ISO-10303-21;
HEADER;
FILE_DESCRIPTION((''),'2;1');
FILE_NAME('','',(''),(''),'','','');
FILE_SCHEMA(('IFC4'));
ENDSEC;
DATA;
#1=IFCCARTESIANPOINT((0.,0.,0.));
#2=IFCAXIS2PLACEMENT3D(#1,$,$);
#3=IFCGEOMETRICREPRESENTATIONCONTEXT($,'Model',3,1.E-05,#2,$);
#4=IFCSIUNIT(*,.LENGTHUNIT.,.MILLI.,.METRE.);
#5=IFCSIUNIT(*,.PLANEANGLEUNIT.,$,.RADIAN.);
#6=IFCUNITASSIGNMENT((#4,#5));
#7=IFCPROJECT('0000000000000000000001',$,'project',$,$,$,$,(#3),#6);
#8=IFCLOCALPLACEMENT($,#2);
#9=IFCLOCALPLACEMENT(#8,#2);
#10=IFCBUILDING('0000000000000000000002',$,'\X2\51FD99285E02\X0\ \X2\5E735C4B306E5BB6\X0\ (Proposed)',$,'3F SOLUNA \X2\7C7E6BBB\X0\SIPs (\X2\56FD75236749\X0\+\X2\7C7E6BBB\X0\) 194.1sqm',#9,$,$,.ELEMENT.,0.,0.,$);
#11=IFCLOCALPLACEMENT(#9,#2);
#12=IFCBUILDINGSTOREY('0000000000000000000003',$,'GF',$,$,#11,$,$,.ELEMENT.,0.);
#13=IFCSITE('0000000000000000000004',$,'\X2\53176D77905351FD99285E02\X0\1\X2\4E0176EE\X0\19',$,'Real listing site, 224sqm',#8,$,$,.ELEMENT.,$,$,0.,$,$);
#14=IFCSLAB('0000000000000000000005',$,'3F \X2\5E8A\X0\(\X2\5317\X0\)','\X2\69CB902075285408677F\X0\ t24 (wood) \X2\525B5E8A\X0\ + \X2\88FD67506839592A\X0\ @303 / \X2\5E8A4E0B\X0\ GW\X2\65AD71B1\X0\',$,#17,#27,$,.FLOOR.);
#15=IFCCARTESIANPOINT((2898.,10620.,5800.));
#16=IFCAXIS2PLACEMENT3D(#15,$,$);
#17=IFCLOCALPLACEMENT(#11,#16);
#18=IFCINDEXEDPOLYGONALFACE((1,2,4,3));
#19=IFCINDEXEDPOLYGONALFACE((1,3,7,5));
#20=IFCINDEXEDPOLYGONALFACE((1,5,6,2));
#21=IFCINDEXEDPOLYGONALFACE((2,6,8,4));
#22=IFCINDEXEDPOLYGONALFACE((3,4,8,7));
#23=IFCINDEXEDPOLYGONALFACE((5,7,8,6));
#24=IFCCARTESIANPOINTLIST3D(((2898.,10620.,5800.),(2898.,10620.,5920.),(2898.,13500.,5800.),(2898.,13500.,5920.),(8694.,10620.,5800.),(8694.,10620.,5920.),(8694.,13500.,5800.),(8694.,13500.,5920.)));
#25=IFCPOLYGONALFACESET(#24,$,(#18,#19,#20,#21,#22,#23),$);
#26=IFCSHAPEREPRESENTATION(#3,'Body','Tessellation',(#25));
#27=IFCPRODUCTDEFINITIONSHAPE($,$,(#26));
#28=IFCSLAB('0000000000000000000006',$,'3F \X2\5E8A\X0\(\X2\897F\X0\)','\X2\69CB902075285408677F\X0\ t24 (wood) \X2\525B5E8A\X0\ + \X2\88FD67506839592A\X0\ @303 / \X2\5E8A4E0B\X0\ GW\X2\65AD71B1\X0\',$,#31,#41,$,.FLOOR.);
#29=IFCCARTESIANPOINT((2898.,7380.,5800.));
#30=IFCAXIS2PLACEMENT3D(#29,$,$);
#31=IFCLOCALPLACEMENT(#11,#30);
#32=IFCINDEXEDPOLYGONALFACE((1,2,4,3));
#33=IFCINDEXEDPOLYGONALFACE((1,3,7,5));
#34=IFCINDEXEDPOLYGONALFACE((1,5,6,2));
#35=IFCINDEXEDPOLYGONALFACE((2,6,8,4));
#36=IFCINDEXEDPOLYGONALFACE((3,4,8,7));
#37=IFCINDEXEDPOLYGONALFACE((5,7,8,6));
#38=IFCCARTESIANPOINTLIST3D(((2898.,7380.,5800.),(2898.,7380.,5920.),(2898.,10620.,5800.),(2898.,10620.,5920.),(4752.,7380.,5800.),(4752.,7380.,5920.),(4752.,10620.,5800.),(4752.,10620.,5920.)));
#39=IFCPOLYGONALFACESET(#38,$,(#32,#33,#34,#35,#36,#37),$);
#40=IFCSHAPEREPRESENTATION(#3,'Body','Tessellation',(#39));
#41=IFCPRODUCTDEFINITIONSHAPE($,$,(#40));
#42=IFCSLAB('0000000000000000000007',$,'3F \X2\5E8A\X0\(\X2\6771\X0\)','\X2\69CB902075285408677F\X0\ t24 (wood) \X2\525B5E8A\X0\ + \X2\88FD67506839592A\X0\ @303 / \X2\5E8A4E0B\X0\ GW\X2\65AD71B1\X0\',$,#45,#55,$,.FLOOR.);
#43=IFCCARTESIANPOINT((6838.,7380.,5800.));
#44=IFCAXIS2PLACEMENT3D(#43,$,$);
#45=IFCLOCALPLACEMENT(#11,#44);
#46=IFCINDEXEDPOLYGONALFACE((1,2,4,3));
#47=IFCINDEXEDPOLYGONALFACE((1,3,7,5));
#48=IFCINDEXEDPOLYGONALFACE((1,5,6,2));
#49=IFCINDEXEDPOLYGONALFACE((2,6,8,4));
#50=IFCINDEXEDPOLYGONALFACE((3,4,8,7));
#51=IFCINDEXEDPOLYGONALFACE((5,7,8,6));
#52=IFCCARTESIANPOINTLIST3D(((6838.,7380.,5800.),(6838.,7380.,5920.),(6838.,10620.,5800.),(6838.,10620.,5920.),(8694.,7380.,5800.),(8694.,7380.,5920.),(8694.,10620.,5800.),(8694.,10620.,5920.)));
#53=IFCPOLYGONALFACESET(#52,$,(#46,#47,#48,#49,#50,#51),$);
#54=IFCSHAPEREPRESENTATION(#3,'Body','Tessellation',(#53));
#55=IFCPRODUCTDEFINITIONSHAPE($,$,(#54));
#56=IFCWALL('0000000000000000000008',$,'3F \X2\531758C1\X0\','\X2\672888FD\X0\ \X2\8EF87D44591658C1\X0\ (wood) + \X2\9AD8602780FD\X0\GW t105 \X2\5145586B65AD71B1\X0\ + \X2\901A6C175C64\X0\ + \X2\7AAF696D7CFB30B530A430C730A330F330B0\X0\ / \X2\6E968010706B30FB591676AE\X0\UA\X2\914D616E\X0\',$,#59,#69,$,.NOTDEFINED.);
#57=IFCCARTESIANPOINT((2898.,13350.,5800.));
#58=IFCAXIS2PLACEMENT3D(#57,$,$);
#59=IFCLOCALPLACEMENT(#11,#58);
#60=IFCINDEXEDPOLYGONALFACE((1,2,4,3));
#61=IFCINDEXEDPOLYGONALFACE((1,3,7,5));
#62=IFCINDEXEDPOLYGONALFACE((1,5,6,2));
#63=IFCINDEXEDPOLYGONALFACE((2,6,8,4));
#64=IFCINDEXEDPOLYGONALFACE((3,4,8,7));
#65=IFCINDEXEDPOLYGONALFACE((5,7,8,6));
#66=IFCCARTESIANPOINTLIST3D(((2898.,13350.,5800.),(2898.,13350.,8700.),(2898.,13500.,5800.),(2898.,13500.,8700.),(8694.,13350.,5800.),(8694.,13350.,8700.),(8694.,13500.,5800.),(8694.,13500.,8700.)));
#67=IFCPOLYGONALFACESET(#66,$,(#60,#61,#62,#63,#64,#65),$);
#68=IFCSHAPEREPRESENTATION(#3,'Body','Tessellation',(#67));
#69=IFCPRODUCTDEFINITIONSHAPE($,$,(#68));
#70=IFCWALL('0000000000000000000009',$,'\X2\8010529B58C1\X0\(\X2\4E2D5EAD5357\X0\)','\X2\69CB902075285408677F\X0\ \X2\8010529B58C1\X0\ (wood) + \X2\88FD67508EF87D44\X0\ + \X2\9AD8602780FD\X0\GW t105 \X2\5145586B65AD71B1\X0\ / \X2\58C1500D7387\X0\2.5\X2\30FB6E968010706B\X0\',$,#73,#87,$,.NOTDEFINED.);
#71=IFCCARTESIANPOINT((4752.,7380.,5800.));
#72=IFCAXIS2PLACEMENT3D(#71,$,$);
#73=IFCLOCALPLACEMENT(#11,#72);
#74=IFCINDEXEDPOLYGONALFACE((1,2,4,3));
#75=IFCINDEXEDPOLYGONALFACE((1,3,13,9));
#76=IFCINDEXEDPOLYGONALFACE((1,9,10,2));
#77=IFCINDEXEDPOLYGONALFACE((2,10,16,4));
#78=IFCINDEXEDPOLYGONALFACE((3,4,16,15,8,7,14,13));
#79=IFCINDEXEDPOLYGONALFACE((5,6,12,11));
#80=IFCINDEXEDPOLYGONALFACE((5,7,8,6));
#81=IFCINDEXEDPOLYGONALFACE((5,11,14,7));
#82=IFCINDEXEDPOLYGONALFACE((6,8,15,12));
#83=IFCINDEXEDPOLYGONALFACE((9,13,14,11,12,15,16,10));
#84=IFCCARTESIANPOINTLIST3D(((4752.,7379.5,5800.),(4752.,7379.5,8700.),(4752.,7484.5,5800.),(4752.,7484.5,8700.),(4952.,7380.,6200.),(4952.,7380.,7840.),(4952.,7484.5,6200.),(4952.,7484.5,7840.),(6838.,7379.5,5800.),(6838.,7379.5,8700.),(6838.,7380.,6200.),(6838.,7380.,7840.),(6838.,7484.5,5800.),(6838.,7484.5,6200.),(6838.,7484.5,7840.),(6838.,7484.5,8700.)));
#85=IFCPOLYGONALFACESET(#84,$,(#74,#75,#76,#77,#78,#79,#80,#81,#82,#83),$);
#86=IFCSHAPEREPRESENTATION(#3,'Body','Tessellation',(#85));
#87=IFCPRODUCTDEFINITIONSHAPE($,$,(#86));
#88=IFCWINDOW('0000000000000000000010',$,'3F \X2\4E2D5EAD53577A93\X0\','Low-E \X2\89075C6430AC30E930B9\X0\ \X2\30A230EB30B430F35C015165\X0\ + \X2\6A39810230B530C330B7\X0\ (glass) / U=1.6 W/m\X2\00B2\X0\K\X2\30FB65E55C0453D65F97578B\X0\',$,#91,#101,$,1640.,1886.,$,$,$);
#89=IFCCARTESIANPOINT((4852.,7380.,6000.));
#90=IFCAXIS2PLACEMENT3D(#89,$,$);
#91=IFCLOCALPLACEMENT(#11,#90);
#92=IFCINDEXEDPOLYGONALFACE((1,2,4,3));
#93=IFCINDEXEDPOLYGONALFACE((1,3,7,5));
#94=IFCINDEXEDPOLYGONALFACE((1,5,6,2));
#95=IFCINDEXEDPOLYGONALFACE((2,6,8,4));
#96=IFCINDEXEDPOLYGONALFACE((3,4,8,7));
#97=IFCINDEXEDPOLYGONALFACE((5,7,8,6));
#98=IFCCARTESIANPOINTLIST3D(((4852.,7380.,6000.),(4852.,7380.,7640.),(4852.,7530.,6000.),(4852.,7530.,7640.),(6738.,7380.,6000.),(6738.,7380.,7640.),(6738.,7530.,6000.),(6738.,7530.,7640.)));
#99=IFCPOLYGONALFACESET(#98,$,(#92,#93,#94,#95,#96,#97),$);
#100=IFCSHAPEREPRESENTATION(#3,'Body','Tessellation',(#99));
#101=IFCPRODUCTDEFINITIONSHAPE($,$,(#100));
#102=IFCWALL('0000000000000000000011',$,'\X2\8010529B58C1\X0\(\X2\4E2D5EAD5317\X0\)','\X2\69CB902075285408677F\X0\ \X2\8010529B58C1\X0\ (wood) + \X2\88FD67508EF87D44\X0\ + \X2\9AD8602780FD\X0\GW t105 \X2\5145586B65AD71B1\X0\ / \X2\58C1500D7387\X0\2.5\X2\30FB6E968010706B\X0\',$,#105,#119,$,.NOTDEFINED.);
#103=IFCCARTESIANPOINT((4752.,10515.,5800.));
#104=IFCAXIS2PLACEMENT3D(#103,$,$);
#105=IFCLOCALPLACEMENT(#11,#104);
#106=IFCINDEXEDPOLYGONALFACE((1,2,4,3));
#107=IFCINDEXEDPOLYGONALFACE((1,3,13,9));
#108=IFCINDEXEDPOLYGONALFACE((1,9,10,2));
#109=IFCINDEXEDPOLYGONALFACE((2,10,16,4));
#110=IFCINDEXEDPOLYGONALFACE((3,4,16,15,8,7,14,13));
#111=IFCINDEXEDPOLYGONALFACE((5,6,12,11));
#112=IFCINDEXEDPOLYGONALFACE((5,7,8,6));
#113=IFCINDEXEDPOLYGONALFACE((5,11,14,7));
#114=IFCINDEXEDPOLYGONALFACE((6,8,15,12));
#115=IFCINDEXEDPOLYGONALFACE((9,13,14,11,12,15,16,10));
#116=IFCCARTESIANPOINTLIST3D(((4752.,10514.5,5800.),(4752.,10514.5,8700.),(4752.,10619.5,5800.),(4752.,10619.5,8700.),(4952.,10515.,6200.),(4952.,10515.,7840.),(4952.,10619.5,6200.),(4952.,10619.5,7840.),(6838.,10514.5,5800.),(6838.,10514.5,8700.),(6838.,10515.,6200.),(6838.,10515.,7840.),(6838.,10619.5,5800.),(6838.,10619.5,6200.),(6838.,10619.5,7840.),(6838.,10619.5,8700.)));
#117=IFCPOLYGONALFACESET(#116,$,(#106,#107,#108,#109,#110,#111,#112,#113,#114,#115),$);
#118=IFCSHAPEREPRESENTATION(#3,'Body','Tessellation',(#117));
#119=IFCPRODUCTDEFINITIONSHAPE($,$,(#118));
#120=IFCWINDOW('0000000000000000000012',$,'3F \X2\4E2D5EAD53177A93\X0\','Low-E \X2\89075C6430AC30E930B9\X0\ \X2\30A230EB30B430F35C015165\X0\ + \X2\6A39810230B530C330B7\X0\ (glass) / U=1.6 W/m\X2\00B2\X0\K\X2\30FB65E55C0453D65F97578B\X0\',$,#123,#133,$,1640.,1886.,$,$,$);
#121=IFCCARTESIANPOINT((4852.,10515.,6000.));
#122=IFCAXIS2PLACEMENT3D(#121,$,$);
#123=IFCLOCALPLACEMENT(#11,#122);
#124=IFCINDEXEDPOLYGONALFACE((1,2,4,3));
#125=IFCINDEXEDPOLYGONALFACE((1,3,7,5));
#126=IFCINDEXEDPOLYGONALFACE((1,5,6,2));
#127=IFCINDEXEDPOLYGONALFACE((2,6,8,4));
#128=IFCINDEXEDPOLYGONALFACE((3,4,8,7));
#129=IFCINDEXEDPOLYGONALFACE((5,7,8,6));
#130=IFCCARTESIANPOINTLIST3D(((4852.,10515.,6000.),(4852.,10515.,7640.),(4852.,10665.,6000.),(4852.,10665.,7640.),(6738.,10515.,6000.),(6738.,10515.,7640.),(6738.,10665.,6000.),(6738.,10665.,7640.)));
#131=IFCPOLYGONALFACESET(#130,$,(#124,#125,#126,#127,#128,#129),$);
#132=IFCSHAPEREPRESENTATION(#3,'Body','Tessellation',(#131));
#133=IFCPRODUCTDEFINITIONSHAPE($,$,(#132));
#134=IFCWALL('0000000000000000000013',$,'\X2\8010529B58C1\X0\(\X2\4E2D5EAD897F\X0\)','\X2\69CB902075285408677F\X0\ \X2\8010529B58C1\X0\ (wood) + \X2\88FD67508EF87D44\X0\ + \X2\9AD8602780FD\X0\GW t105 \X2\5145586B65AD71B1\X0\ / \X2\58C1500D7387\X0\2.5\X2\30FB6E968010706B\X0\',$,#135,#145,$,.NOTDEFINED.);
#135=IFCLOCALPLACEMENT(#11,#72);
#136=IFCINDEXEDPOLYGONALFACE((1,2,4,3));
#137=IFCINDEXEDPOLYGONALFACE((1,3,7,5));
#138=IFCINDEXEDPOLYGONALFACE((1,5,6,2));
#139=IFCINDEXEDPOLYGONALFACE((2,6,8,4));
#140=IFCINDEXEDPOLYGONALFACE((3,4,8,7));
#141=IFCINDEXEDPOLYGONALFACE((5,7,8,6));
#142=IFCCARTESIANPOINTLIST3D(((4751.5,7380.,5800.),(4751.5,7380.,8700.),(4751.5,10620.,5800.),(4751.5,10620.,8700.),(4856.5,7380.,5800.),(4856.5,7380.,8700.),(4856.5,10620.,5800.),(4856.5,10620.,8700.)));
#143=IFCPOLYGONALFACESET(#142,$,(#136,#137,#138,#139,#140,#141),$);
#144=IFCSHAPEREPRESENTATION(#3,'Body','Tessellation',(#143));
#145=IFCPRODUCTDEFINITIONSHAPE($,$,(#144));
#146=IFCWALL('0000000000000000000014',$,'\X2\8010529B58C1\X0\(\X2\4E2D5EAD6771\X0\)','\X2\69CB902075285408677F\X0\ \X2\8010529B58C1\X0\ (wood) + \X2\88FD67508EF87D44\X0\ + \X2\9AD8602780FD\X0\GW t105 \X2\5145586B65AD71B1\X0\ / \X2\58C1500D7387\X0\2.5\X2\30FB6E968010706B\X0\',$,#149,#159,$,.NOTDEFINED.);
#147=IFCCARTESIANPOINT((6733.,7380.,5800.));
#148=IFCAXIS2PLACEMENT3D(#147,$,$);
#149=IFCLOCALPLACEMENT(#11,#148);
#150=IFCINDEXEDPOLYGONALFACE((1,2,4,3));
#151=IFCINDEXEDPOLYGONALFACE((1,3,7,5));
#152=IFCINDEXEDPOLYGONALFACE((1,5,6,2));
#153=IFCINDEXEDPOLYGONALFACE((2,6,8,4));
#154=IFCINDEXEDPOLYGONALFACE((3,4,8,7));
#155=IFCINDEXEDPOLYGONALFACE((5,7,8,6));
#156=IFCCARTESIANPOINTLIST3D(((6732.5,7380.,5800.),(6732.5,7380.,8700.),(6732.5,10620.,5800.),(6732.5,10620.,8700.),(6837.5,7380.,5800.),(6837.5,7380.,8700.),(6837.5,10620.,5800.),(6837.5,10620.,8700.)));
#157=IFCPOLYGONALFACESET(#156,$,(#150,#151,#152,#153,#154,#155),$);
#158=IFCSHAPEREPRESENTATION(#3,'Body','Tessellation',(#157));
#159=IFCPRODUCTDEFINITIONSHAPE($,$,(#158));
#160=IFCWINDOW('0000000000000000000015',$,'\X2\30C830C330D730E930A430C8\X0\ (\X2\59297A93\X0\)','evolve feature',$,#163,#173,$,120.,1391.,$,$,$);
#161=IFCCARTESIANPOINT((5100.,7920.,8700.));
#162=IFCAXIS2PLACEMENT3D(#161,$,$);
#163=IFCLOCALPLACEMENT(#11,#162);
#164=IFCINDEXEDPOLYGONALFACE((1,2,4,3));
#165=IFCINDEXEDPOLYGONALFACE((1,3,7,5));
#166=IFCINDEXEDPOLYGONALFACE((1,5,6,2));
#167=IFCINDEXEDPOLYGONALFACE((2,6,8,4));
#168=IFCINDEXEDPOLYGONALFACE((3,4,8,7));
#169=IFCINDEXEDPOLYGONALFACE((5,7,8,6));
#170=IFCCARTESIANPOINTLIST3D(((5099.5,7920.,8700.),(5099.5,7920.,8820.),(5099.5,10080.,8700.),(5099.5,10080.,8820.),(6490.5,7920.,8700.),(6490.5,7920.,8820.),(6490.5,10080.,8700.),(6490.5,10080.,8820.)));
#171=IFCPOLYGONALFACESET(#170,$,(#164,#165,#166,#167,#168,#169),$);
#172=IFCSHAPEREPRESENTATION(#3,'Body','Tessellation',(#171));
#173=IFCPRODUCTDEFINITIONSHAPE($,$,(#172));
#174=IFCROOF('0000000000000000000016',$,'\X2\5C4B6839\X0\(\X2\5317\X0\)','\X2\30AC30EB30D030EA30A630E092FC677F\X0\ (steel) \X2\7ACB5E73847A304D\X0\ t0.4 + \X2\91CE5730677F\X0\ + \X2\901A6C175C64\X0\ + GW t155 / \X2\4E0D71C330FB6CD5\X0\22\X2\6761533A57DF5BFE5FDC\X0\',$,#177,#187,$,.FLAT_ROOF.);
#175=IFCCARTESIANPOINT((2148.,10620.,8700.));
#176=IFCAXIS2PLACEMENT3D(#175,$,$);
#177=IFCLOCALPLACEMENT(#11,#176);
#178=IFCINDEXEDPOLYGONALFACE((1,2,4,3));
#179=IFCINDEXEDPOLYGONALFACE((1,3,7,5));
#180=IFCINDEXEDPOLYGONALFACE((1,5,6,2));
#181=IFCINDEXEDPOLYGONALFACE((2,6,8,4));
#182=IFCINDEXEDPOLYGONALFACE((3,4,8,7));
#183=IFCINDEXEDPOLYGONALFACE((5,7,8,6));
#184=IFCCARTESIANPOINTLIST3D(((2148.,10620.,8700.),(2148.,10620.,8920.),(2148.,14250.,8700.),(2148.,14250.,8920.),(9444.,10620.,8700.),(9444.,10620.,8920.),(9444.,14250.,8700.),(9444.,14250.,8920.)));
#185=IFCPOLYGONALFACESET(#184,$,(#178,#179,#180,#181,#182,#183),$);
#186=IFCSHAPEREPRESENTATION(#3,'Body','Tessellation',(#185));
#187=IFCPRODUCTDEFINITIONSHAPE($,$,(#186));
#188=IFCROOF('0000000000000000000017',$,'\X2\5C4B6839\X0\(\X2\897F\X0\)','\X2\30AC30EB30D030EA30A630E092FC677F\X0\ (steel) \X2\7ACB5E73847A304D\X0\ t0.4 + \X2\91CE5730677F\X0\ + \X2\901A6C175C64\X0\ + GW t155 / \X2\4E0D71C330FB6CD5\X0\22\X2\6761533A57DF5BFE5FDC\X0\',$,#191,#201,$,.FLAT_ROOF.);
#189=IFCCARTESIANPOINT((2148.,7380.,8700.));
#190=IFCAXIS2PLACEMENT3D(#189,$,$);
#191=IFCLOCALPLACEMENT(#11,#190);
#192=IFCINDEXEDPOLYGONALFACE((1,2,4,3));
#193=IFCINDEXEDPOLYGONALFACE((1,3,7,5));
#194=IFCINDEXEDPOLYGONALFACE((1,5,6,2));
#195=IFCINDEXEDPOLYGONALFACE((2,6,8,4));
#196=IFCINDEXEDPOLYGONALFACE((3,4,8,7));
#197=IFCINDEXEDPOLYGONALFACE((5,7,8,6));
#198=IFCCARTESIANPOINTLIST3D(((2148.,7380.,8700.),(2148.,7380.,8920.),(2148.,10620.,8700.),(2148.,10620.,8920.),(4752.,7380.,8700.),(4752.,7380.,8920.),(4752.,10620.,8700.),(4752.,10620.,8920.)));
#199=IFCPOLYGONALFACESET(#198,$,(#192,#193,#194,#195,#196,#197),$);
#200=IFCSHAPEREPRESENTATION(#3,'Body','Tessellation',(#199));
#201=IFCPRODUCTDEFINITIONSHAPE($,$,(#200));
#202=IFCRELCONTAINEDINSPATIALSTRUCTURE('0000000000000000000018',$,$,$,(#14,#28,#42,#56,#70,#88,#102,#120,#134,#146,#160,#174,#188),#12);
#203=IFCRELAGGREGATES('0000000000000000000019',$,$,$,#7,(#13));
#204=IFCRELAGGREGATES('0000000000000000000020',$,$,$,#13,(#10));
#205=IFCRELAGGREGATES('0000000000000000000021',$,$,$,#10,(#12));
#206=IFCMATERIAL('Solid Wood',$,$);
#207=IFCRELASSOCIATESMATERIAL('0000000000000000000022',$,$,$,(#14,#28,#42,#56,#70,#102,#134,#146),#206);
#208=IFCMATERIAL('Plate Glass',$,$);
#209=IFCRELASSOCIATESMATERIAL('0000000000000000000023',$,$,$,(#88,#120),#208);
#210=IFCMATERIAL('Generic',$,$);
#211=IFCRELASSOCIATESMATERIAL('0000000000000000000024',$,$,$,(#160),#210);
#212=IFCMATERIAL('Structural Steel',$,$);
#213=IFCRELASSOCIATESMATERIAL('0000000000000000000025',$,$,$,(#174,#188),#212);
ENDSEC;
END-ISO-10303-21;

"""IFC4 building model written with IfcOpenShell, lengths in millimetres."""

from ifc_helpers import new_model, si_unit, frame, frame_2d, origin, place, context, project, spatial, rectangle, extrude, material, element, fill, save


model = new_model("IFC4")

# Units and contexts
model_context = context("Model", 3, precision=1e-05, world=origin())
ifc_project = project(units=[si_unit("LENGTHUNIT", "METRE", prefix="MILLI"), si_unit("PLANEANGLEUNIT", "RADIAN")], contexts=[model_context])

# Site, building, storey
site_placement = place(None, origin())
site = spatial("IfcSite", under=ifc_project, at=site_placement, Name="北海道函館市1丁目19", ObjectType="Real listing site, 224sqm", CompositionType="ELEMENT", RefElevation=0.0)
building_placement = place(site_placement, origin())
building = spatial("IfcBuilding", under=site, at=building_placement, Name="函館市 平屋の家 (Proposed)", ObjectType="3F SOLUNA 籾殻SIPs (国産杉+籾殻) 194.1sqm", CompositionType="ELEMENT", ElevationOfRefHeight=0.0, ElevationOfTerrain=0.0)
storey_placement = place(building_placement, origin())
storey = spatial("IfcBuildingStorey", under=building, at=storey_placement, Name="GF", CompositionType="ELEMENT", Elevation=0.0)

# Slabs
ifc_material_1 = material(Name="Solid Wood")
slab_1_placement = place(storey_placement, frame((2898.0, 10620.0, 5800.0)))
element("IfcSlab", 1, at=slab_1_placement, inside=storey, material=ifc_material_1, Name="3F 床(北)", Description="構造用合板 t24 (wood) 剛床 + 製材根太 @303 / 床下 GW断熱", PredefinedType="FLOOR", context=model_context, shape_type="SweptSolid", body=[
    extrude(rectangle(XDim=5796.0, YDim=2880.0, at=frame_2d((2898.0, 1440.0))), frame((2898.0, 10620.0, 5800.0)), (0.0, 0.0, 1.0), 120.0),
])
slab_2_placement = place(storey_placement, frame((2898.0, 7380.0, 5800.0)))
element("IfcSlab", 2, at=slab_2_placement, inside=storey, material=ifc_material_1, Name="3F 床(西)", Description="構造用合板 t24 (wood) 剛床 + 製材根太 @303 / 床下 GW断熱", PredefinedType="FLOOR", context=model_context, shape_type="SweptSolid", body=[
    extrude(rectangle(XDim=1854.0, YDim=3240.0, at=frame_2d((927.0, 1620.0))), frame((2898.0, 7380.0, 5800.0)), (0.0, 0.0, 1.0), 120.0),
])
slab_3_placement = place(storey_placement, frame((6838.0, 7380.0, 5800.0)))
element("IfcSlab", 3, at=slab_3_placement, inside=storey, material=ifc_material_1, Name="3F 床(東)", Description="構造用合板 t24 (wood) 剛床 + 製材根太 @303 / 床下 GW断熱", PredefinedType="FLOOR", context=model_context, shape_type="SweptSolid", body=[
    extrude(rectangle(XDim=1856.0, YDim=3240.0, at=frame_2d((928.0, 1620.0))), frame((6838.0, 7380.0, 5800.0)), (0.0, 0.0, 1.0), 120.0),
])

# Wall
wall_1_placement = place(storey_placement, frame((2898.0, 13350.0, 5800.0)))
element("IfcWall", 4, at=wall_1_placement, inside=storey, material=ifc_material_1, Name="3F 北壁", Description="木製 軸組外壁 (wood) + 高性能GW t105 充填断熱 + 通気層 + 窯業系サイディング / 準耐火・外皮UA配慮", PredefinedType="NOTDEFINED", context=model_context, shape_type="SweptSolid", body=[
    extrude(rectangle(XDim=5796.0, YDim=150.0, at=frame_2d((2898.0, 75.0))), frame((2898.0, 13350.0, 5800.0)), (0.0, 0.0, 1.0), 2900.0),
])

# Walls, openings, windows
wall_2_placement = place(storey_placement, frame((4752.0, 7380.0, 5800.0)))
wall_2 = element("IfcWall", 5, at=wall_2_placement, inside=storey, material=ifc_material_1, Name="耐力壁(中庭南)", Description="構造用合板 耐力壁 (wood) + 製材軸組 + 高性能GW t105 充填断熱 / 壁倍率2.5・準耐火", PredefinedType="NOTDEFINED", context=model_context, shape_type="SweptSolid", body=[
    extrude(rectangle(XDim=2086.0, YDim=105.0, at=frame_2d((1043.0, 52.0))), frame((4752.0, 7380.0, 5800.0)), (0.0, 0.0, 1.0), 2900.0),
])
opening_1_placement = place(storey_placement, frame((4852.0, 7380.0, 6000.0)))
opening_1 = element("IfcOpeningElement", 6, at=opening_1_placement, cuts=wall_2, PredefinedType="NOTDEFINED", context=model_context, shape_type="SweptSolid", body=[
    extrude(rectangle(XDim=1886.0, YDim=150.0, at=frame_2d((943.0, 75.0))), frame((4852.0, 7380.0, 6000.0)), (0.0, 0.0, 1.0), 1640.0),
])
ifc_material_2 = material(Name="Plate Glass")
window_1_placement = place(storey_placement, frame((4852.0, 7380.0, 6000.0)))
window_1 = element("IfcWindow", 7, at=window_1_placement, inside=storey, material=ifc_material_2, Name="3F 中庭南窓", Description="Low-E 複層ガラス アルゴン封入 + 樹脂サッシ (glass) / U=1.6 W/m²K・日射取得型", OverallHeight=1640.0, OverallWidth=1886.0, context=model_context, shape_type="SweptSolid", body=[
    extrude(rectangle(XDim=1886.0, YDim=150.0, at=frame_2d((943.0, 75.0))), frame((4852.0, 7380.0, 6000.0)), (0.0, 0.0, 1.0), 1640.0),
])
fill(opening_1, window_1)
wall_3_placement = place(storey_placement, frame((4752.0, 10515.0, 5800.0)))
wall_3 = element("IfcWall", 8, at=wall_3_placement, inside=storey, material=ifc_material_1, Name="耐力壁(中庭北)", Description="構造用合板 耐力壁 (wood) + 製材軸組 + 高性能GW t105 充填断熱 / 壁倍率2.5・準耐火", PredefinedType="NOTDEFINED", context=model_context, shape_type="SweptSolid", body=[
    extrude(rectangle(XDim=2086.0, YDim=105.0, at=frame_2d((1043.0, 52.0))), frame((4752.0, 10515.0, 5800.0)), (0.0, 0.0, 1.0), 2900.0),
])
opening_2_placement = place(storey_placement, frame((4852.0, 10515.0, 6000.0)))
opening_2 = element("IfcOpeningElement", 9, at=opening_2_placement, cuts=wall_3, PredefinedType="NOTDEFINED", context=model_context, shape_type="SweptSolid", body=[
    extrude(rectangle(XDim=1886.0, YDim=150.0, at=frame_2d((943.0, 75.0))), frame((4852.0, 10515.0, 6000.0)), (0.0, 0.0, 1.0), 1640.0),
])
window_2_placement = place(storey_placement, frame((4852.0, 10515.0, 6000.0)))
window_2 = element("IfcWindow", 10, at=window_2_placement, inside=storey, material=ifc_material_2, Name="3F 中庭北窓", Description="Low-E 複層ガラス アルゴン封入 + 樹脂サッシ (glass) / U=1.6 W/m²K・日射取得型", OverallHeight=1640.0, OverallWidth=1886.0, context=model_context, shape_type="SweptSolid", body=[
    extrude(rectangle(XDim=1886.0, YDim=150.0, at=frame_2d((943.0, 75.0))), frame((4852.0, 10515.0, 6000.0)), (0.0, 0.0, 1.0), 1640.0),
])
fill(opening_2, window_2)

# Walls
wall_4_placement = place(storey_placement, frame((4752.0, 7380.0, 5800.0)))
element("IfcWall", 11, at=wall_4_placement, inside=storey, material=ifc_material_1, Name="耐力壁(中庭西)", Description="構造用合板 耐力壁 (wood) + 製材軸組 + 高性能GW t105 充填断熱 / 壁倍率2.5・準耐火", PredefinedType="NOTDEFINED", context=model_context, shape_type="SweptSolid", body=[
    extrude(rectangle(XDim=105.0, YDim=3240.0, at=frame_2d((52.0, 1620.0))), frame((4752.0, 7380.0, 5800.0)), (0.0, 0.0, 1.0), 2900.0),
])
wall_5_placement = place(storey_placement, frame((6733.0, 7380.0, 5800.0)))
element("IfcWall", 12, at=wall_5_placement, inside=storey, material=ifc_material_1, Name="耐力壁(中庭東)", Description="構造用合板 耐力壁 (wood) + 製材軸組 + 高性能GW t105 充填断熱 / 壁倍率2.5・準耐火", PredefinedType="NOTDEFINED", context=model_context, shape_type="SweptSolid", body=[
    extrude(rectangle(XDim=105.0, YDim=3240.0, at=frame_2d((52.0, 1620.0))), frame((6733.0, 7380.0, 5800.0)), (0.0, 0.0, 1.0), 2900.0),
])

# Window
ifc_material_3 = material(Name="Generic")
window_3_placement = place(storey_placement, frame((5100.0, 7920.0, 8700.0)))
element("IfcWindow", 13, at=window_3_placement, inside=storey, material=ifc_material_3, Name="トップライト (天窓)", Description="evolve feature", OverallHeight=120.0, OverallWidth=1391.0, context=model_context, shape_type="SweptSolid", body=[
    extrude(rectangle(XDim=1391.0, YDim=2160.0, at=frame_2d((695.0, 1080.0))), frame((5100.0, 7920.0, 8700.0)), (0.0, 0.0, 1.0), 120.0),
])

# Roofs
ifc_material_4 = material(Name="Structural Steel")
for number, where, name in (
    (14, (2148.0, 10620.0, 8700.0), "屋根(北)"),
):
    element("IfcRoof", number, at=place(storey_placement, frame(where)), inside=storey, material=ifc_material_4, Name=name, Description="ガルバリウム鋼板 (steel) 立平葺き t0.4 + 野地板 + 通気層 + GW t155 / 不燃・法22条区域対応", PredefinedType="FLAT_ROOF", context=model_context, shape_type="SweptSolid", body=[
        extrude(rectangle(XDim=7296.0, YDim=3630.0, at=frame_2d((3648.0, 1815.0))), frame((2148.0, 10620.0, 8700.0)), (0.0, 0.0, 1.0), 220.0),
    ])
roof_1_placement = place(storey_placement, frame((2148.0, 7380.0, 8700.0)))
element("IfcRoof", 15, at=roof_1_placement, inside=storey, material=ifc_material_4, Name="屋根(西)", Description="ガルバリウム鋼板 (steel) 立平葺き t0.4 + 野地板 + 通気層 + GW t155 / 不燃・法22条区域対応", PredefinedType="FLAT_ROOF", context=model_context, shape_type="SweptSolid", body=[
    extrude(rectangle(XDim=2604.0, YDim=3240.0, at=frame_2d((1302.0, 1620.0))), frame((2148.0, 7380.0, 8700.0)), (0.0, 0.0, 1.0), 220.0),
])

save(model, "model.ifc")
